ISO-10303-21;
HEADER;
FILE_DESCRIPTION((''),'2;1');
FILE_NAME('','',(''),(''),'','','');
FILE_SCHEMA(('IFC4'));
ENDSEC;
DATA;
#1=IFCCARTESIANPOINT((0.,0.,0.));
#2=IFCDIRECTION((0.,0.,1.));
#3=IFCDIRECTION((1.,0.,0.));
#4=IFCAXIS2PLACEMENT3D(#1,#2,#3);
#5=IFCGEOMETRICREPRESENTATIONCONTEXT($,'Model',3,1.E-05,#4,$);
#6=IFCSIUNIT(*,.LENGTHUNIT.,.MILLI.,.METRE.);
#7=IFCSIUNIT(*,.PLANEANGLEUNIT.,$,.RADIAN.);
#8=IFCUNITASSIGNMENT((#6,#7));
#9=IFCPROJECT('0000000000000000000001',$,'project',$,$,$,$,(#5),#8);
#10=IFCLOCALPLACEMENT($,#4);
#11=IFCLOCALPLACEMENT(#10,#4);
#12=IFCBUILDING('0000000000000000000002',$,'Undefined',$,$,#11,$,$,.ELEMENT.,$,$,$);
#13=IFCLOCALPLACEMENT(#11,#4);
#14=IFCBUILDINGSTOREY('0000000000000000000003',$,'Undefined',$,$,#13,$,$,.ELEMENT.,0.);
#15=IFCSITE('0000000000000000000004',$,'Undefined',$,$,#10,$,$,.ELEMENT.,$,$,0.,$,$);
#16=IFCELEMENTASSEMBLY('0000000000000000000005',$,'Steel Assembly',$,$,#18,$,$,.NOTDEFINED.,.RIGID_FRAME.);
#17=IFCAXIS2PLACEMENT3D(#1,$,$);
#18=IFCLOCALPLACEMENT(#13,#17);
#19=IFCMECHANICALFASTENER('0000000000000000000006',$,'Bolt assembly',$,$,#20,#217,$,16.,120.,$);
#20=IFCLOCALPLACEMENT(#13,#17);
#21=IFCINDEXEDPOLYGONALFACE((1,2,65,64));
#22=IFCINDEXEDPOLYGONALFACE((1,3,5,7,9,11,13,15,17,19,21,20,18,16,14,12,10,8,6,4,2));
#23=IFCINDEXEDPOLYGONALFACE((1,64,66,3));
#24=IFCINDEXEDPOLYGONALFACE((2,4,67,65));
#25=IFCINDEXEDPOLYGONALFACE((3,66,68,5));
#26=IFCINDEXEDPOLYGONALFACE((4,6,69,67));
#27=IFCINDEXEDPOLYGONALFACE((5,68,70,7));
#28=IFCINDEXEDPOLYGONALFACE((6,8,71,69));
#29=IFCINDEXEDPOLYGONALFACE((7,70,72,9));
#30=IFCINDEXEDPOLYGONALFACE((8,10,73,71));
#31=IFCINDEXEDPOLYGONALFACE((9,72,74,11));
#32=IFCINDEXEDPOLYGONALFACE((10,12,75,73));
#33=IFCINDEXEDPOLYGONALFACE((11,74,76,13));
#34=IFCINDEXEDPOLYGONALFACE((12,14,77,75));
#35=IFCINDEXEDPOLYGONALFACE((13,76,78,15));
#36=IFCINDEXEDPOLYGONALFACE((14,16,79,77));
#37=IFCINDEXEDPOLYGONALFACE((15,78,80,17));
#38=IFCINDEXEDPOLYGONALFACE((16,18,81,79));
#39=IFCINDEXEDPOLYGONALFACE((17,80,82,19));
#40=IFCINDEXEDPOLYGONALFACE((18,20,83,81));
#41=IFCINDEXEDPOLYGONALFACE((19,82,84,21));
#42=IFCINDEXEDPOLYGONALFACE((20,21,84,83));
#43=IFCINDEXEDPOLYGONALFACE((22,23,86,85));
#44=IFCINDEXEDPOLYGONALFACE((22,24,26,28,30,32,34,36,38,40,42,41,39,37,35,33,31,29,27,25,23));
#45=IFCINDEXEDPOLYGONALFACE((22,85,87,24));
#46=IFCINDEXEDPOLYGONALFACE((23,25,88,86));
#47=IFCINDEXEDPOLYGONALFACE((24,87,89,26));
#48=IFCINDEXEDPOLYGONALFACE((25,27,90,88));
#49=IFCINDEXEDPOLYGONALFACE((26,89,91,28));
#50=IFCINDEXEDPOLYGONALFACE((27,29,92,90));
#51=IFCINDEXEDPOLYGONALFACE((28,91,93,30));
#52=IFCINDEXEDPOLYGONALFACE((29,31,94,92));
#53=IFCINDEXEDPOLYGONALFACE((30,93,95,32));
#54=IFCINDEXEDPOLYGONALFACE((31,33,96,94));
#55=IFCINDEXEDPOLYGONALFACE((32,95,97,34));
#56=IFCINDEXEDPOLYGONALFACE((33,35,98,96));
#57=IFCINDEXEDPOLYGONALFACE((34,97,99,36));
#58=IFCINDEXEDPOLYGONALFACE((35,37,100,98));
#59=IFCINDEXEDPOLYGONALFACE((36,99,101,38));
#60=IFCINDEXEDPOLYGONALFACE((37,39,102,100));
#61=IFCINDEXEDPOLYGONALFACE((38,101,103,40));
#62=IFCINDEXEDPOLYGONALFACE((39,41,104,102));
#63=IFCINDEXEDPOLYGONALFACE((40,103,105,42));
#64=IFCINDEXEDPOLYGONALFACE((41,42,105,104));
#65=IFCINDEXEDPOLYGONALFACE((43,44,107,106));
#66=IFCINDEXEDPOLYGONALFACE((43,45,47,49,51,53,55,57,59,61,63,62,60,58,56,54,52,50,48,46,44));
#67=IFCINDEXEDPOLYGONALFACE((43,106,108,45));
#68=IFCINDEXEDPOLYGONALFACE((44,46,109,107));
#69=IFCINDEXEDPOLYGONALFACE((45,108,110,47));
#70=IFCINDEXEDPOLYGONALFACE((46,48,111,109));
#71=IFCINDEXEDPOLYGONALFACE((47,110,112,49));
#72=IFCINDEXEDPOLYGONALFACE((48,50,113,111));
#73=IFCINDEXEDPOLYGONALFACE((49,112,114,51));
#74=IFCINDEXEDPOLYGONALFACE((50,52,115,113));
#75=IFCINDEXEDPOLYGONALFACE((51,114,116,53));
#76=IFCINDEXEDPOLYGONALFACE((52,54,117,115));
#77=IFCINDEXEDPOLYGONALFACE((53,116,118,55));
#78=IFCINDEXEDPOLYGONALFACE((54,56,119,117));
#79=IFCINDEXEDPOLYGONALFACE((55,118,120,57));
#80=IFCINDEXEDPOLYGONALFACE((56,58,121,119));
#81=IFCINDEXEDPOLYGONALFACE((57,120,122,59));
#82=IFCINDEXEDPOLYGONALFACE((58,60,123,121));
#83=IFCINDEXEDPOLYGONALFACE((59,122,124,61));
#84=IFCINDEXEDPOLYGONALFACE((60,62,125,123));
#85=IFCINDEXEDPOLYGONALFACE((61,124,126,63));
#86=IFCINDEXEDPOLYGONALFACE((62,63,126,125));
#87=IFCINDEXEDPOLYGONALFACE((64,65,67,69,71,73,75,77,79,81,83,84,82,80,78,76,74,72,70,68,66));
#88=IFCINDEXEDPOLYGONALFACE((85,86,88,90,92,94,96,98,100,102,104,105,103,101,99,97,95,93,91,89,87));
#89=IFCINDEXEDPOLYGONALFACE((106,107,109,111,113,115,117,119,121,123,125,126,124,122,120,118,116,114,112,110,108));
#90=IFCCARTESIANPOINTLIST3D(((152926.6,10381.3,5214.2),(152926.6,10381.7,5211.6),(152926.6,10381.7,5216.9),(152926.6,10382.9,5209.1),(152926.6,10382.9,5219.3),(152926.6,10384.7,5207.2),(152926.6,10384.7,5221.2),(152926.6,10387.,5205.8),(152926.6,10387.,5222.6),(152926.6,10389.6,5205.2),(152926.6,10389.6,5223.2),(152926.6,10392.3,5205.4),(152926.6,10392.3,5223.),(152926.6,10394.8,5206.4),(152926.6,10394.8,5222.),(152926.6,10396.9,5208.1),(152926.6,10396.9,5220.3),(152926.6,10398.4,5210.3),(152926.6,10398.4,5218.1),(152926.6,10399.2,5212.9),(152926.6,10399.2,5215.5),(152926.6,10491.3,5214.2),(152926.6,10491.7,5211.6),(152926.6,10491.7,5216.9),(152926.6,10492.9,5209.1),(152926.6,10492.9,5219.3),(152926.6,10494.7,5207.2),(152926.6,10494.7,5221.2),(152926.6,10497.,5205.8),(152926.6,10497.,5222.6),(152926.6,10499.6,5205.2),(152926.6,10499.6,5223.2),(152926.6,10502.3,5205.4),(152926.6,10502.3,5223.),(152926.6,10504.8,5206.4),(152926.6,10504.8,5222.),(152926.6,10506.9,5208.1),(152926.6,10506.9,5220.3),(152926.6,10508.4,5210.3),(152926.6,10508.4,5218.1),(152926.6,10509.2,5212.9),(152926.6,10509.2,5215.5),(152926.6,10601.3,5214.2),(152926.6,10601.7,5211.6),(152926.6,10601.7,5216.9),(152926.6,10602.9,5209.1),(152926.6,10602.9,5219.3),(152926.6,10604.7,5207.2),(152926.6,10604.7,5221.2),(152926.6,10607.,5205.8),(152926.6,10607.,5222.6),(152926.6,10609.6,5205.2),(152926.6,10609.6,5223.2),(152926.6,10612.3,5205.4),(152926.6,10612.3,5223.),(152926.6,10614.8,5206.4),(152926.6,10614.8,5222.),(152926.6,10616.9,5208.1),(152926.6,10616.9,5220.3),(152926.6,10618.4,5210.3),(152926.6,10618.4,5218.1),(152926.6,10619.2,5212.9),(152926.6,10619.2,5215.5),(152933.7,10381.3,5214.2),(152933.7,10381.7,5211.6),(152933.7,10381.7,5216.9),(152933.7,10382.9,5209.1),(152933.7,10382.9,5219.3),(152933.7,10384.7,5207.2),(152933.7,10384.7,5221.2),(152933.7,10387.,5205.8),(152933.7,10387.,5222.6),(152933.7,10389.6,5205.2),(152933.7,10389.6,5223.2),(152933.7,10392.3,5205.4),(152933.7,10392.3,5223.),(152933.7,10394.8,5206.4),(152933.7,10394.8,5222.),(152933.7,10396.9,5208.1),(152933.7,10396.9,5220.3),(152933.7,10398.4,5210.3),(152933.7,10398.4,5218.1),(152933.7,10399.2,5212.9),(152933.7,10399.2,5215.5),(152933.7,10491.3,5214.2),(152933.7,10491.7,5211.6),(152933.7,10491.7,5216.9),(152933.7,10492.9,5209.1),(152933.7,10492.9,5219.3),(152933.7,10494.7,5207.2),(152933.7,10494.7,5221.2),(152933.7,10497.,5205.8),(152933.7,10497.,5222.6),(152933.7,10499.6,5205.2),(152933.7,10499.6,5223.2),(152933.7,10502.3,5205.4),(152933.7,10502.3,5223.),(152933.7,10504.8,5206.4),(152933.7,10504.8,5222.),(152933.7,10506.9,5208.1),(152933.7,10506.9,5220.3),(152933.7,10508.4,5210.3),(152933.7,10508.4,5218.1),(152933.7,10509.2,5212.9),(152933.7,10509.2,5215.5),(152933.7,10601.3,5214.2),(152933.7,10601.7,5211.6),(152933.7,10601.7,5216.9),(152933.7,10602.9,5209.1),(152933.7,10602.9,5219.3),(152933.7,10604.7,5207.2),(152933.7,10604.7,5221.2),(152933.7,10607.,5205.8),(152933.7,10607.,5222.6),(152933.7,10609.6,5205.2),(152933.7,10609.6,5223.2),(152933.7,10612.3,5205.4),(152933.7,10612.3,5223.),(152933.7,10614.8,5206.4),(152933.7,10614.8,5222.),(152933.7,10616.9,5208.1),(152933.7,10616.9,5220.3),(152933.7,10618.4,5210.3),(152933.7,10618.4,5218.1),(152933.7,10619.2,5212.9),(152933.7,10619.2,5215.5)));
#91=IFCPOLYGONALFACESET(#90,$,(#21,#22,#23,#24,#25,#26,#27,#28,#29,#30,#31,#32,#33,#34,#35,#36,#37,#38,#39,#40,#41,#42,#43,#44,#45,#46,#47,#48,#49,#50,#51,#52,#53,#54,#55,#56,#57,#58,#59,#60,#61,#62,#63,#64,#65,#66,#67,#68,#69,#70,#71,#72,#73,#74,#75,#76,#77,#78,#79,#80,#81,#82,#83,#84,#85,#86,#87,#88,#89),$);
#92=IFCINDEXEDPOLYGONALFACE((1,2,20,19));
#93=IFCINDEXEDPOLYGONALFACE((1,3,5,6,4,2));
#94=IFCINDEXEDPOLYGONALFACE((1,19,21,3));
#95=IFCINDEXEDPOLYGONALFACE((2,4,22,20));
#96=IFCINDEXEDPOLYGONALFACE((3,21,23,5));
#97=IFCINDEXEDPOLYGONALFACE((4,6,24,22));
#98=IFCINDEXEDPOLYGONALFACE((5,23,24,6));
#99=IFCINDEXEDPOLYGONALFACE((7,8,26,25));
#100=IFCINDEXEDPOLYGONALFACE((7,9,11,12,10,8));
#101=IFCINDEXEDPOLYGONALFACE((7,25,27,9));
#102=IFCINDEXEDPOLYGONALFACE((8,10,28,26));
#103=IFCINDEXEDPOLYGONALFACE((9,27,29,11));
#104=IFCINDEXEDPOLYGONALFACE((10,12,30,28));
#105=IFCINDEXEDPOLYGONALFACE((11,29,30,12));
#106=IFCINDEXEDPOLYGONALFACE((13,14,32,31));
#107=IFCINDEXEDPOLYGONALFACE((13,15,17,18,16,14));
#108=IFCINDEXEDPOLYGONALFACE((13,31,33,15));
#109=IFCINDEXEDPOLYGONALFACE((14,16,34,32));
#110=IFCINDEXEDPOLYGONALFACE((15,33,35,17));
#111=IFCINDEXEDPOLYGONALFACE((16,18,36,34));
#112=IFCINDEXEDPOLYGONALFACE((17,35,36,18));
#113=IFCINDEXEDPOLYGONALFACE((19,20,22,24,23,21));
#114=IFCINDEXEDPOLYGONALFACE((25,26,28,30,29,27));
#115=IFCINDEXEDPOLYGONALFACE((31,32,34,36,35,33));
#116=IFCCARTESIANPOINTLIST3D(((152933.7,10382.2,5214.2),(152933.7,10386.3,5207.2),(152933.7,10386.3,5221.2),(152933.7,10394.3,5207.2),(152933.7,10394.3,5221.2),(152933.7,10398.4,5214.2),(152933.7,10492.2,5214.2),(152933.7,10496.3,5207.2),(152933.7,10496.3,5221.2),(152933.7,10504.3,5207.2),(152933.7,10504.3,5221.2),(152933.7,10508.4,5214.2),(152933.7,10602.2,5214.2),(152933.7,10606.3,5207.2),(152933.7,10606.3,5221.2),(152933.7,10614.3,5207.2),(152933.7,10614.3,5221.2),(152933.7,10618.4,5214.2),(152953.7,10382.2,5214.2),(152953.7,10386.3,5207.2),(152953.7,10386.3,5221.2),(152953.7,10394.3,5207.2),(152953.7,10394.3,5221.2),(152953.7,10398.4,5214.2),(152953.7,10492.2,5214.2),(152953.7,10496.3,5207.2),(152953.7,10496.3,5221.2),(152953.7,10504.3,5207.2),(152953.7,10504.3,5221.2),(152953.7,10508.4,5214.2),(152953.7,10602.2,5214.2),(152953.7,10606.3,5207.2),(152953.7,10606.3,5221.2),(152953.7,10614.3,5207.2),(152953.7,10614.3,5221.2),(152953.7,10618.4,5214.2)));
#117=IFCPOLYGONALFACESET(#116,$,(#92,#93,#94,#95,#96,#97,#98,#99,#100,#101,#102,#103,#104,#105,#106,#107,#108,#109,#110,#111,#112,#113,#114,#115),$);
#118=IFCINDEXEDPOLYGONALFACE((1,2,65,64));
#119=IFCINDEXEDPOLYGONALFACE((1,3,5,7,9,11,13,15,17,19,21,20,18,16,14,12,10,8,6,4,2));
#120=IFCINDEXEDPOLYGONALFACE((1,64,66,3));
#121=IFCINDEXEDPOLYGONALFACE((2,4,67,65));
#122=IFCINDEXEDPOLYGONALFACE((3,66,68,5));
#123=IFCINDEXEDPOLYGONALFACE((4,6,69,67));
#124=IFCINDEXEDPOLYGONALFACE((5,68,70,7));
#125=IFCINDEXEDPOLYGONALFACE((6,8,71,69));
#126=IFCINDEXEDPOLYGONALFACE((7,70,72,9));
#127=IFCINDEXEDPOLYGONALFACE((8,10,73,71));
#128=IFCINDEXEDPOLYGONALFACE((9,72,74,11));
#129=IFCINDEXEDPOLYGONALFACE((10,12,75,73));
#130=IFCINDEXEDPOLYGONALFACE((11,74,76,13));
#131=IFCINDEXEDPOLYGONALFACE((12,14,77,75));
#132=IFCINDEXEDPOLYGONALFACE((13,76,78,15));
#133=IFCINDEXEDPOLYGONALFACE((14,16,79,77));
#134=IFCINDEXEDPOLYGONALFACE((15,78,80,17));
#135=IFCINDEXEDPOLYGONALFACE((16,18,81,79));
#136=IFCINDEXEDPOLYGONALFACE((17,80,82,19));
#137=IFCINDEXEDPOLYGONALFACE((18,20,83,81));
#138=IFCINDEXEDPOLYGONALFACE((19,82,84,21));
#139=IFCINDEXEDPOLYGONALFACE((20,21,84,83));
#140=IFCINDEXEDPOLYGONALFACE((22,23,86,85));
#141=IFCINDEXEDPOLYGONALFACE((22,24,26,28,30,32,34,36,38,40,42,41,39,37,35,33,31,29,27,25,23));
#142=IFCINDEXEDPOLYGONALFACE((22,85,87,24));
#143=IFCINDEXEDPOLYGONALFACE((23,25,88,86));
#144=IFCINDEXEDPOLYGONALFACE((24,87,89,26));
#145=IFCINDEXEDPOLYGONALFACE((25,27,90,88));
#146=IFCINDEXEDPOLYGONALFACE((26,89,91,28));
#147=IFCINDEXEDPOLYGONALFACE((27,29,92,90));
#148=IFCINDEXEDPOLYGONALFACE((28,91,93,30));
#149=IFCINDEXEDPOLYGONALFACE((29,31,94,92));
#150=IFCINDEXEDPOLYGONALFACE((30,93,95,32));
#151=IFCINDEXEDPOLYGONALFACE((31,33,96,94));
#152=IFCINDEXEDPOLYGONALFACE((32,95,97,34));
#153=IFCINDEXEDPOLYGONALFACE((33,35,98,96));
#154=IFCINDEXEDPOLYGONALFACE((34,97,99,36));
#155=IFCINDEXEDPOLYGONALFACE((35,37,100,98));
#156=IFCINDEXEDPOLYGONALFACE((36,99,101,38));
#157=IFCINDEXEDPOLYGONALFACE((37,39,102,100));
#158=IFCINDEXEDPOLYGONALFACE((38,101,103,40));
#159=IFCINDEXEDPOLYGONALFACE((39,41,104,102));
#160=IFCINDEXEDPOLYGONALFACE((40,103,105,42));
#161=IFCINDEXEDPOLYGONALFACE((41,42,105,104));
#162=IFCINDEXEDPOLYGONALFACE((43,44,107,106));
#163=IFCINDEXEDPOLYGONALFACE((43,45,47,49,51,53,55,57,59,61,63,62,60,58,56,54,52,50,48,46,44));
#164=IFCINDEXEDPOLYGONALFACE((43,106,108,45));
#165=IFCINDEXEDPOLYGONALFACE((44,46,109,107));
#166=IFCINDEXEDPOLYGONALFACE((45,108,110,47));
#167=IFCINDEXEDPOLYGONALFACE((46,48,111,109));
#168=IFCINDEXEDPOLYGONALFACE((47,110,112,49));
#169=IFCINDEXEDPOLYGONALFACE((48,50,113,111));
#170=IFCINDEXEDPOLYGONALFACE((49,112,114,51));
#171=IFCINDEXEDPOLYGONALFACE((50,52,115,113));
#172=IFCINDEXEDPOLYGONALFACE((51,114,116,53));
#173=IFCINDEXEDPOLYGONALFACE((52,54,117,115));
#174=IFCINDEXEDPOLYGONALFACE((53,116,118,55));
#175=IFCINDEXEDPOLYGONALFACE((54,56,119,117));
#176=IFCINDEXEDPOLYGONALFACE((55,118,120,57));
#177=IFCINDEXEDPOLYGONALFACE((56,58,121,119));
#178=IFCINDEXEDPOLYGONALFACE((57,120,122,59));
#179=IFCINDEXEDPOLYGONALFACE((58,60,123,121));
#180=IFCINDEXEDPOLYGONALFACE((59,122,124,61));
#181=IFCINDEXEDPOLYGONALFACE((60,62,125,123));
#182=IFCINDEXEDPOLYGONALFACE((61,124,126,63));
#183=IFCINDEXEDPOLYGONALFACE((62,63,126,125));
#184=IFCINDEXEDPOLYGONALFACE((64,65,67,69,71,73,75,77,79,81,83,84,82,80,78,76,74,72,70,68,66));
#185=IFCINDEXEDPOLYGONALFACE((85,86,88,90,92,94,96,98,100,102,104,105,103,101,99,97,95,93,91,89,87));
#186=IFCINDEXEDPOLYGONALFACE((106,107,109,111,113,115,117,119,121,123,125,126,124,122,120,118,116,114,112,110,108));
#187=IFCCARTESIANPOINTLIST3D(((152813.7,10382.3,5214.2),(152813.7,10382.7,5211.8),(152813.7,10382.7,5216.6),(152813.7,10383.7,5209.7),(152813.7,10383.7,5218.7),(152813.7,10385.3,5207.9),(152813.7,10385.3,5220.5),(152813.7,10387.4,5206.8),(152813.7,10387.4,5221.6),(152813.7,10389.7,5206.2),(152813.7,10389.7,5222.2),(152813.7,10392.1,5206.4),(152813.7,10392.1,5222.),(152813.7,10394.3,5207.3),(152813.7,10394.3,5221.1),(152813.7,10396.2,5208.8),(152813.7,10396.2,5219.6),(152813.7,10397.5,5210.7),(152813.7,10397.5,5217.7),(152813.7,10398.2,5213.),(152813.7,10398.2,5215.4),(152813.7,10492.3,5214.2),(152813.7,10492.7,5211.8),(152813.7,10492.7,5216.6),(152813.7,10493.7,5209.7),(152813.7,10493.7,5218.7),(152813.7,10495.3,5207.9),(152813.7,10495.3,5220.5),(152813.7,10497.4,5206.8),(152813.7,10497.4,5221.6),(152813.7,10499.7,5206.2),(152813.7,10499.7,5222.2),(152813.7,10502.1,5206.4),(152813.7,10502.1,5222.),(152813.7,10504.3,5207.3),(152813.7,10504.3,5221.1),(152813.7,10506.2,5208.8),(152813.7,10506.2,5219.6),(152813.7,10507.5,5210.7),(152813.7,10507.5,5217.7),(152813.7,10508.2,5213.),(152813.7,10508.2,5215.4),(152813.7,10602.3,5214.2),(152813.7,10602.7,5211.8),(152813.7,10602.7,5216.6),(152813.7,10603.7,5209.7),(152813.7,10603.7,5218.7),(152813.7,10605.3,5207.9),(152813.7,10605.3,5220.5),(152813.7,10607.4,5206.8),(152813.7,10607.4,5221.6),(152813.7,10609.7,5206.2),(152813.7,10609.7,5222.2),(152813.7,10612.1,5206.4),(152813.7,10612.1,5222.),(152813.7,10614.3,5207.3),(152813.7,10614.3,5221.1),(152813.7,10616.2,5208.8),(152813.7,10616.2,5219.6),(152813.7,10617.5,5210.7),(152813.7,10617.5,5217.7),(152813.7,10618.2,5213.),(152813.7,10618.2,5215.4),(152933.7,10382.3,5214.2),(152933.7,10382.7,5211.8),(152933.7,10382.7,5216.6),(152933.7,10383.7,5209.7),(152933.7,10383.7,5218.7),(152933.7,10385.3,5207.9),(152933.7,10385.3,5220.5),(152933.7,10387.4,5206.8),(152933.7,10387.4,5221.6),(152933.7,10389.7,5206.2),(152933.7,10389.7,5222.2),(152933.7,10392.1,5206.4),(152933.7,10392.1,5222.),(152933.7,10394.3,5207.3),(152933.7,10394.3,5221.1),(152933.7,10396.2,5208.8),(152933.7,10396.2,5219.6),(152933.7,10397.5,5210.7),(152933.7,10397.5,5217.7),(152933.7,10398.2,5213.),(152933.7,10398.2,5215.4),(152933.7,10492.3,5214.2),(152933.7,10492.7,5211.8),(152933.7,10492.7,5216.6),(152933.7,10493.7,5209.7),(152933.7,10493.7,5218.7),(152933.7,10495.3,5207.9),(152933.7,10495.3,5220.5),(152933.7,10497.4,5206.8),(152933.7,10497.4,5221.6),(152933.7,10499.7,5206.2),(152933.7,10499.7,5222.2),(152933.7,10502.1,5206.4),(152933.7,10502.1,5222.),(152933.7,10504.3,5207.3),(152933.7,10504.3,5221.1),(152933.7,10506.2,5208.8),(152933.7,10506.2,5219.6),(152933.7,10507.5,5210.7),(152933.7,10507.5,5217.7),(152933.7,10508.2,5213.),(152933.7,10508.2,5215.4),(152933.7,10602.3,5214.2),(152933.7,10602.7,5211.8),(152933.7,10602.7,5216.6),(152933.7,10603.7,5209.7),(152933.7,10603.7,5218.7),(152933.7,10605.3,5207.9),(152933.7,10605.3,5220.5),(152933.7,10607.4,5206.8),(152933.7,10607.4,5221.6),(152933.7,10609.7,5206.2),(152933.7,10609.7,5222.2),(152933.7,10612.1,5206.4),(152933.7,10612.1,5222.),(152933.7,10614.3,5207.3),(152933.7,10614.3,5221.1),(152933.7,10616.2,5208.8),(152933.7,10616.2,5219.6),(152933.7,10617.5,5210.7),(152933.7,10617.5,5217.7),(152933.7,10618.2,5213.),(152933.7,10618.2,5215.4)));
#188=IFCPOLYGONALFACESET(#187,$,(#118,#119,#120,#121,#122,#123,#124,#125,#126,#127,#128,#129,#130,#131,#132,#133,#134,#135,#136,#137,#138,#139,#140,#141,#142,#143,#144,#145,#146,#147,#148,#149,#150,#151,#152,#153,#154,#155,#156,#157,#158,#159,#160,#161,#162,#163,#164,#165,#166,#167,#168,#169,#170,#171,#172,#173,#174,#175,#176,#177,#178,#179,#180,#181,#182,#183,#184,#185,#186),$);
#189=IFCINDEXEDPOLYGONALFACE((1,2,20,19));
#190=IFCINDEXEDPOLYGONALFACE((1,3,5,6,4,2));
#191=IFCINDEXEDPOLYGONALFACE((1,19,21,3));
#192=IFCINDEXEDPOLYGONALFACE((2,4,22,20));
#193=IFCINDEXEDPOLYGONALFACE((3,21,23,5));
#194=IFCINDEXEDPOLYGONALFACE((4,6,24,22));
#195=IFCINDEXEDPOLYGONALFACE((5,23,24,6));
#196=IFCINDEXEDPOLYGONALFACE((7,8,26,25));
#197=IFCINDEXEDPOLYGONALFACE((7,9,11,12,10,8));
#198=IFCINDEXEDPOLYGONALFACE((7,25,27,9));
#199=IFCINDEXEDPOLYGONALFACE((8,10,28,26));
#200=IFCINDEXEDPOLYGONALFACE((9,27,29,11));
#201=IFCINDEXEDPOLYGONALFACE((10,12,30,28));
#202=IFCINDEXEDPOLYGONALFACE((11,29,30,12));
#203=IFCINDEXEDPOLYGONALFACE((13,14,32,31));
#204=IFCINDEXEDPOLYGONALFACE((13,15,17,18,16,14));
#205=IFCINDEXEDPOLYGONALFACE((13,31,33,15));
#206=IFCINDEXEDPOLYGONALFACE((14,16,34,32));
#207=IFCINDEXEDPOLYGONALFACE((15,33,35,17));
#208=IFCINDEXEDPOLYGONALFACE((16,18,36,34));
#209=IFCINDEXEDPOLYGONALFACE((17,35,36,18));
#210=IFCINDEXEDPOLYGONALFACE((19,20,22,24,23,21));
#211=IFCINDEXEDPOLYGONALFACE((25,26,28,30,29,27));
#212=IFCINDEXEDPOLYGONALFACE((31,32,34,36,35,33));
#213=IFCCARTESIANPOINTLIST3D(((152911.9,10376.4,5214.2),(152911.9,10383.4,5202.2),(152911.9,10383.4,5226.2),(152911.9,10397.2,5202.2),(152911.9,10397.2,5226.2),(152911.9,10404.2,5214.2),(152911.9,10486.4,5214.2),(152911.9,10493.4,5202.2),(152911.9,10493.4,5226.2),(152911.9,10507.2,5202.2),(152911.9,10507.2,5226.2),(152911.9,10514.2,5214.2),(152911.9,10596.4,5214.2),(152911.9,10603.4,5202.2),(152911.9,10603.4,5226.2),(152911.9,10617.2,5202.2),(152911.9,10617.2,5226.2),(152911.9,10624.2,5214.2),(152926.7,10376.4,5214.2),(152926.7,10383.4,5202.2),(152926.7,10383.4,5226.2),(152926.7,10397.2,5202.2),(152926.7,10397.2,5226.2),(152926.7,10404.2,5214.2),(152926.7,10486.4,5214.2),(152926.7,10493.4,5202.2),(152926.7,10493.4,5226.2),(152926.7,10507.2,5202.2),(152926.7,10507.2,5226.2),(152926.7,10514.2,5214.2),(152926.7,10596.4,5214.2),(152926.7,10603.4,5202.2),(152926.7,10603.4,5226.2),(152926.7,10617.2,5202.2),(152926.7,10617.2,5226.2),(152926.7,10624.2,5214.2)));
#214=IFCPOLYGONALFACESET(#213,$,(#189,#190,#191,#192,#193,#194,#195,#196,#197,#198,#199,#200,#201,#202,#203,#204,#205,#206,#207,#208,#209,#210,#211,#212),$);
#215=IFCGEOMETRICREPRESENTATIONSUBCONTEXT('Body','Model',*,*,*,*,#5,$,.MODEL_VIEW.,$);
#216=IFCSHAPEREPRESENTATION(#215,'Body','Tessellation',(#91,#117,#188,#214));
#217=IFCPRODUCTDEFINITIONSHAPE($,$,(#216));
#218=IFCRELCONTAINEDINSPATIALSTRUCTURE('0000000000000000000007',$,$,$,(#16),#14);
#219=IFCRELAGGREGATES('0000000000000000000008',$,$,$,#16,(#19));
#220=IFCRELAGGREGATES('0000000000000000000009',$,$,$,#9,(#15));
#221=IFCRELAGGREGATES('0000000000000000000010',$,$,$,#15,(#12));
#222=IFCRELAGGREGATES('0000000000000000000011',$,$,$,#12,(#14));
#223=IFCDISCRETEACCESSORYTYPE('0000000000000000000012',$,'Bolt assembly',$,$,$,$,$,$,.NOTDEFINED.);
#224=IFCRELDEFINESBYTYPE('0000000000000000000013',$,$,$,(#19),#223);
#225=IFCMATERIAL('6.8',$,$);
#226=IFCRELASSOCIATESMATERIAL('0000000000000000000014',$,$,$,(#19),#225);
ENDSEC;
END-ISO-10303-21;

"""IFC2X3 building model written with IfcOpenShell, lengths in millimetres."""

from ifc_helpers import new_model, si_unit, frame, origin_with_axes, origin_2d_with_axis, place, context, subcontext, project, spatial, polyline, circle, outline, extrude, source, transform, mapped, material, type_object, element, aggregate, save


model = new_model("IFC2X3")

# Units and contexts
model_context = context("Model", 3, precision=1e-05, world=origin_with_axes())
body_context = subcontext(model_context, "Body", "Model", "MODEL_VIEW")
ifc_project = project(units=[si_unit("LENGTHUNIT", "METRE", prefix="MILLI"), si_unit("PLANEANGLEUNIT", "RADIAN")], contexts=[model_context])

# Site, building, storey
site_placement = place(None, origin_with_axes())
site = spatial("IfcSite", under=ifc_project, at=site_placement, Name="Undefined", CompositionType="ELEMENT", RefElevation=0.0)
building_placement = place(site_placement, origin_with_axes())
building = spatial("IfcBuilding", under=site, at=building_placement, Name="Undefined", CompositionType="ELEMENT")
storey_placement = place(building_placement, origin_with_axes())
storey = spatial("IfcBuildingStorey", under=building, at=storey_placement, Name="Undefined", CompositionType="ELEMENT", Elevation=0.0)

# Element assembly
assembly_1_placement = place(storey_placement, origin_with_axes())
assembly_1 = element("IfcElementAssembly", 1, at=assembly_1_placement, inside=storey, Name="Steel Assembly", AssemblyPlace="NOTDEFINED", PredefinedType="RIGID_FRAME")

# Mechanical fastener
discrete_accessory_type_1 = type_object("IfcDiscreteAccessoryType", Name="Bolt assembly")
ifc_material_1 = material(Name="6.8")
shared_shape_1 = source(origin_with_axes(), body_context, "Body", "SweptSolid", [
    extrude(circle(Radius=9.0, at=origin_2d_with_axis()), frame((0.0, -2.5, 0.0), z_axis=(0.0, 1.0, 0.0), x_axis=(1.0, 0.0, 0.0)), (0.0, 0.0, 1.0), 7.1),
    extrude(outline(polyline([(8.1, 0.0), (4.0, 7.0), (-4.0, 7.0), (-8.1, 0.0), (-4.0, -7.0), (4.0, -7.0), (8.1, 0.0)])), frame((0.0, -22.5, 0.0), z_axis=(0.0, 1.0, 0.0), x_axis=(1.0, 0.0, 0.0)), (0.0, 0.0, 1.0), 20.0),
    extrude(circle(Radius=8.0, at=origin_2d_with_axis()), frame((0.0, -2.5, 0.0), z_axis=(0.0, 1.0, 0.0), x_axis=(1.0, 0.0, 0.0)), (0.0, 0.0, 1.0), 120.0),
    extrude(outline(polyline([(13.9, 0.0), (6.9, 12.0), (-6.9, 12.0), (-13.9, 0.0), (-6.9, -12.0), (6.9, -12.0), (13.9, 0.0)])), frame((0.0, 4.5, 0.0), z_axis=(0.0, 1.0, 0.0), x_axis=(1.0, 0.0, 0.0)), (0.0, 0.0, 1.0), 14.8),
])
mechanical_fastener_1_placement = place(assembly_1_placement, frame((152931.2, 10610.3, 5214.2), z_axis=(0.0, 0.0, -1.0), x_axis=(0.0, -1.0, 0.0)))
mechanical_fastener_1 = element("IfcMechanicalFastener", 2, at=mechanical_fastener_1_placement, type_object=discrete_accessory_type_1, material=ifc_material_1, Name="Bolt assembly", NominalDiameter=16.0, NominalLength=120.0, context=body_context, shape_type="MappedRepresentation", body=[
    mapped(shared_shape_1, transform((0.0, 0.0, 0.0))),
    mapped(shared_shape_1, transform((110.0, 0.0, 0.0))),
    mapped(shared_shape_1, transform((220.0, 0.0, 0.0))),
])
aggregate(assembly_1, [mechanical_fastener_1])

save(model, "model.ifc")
